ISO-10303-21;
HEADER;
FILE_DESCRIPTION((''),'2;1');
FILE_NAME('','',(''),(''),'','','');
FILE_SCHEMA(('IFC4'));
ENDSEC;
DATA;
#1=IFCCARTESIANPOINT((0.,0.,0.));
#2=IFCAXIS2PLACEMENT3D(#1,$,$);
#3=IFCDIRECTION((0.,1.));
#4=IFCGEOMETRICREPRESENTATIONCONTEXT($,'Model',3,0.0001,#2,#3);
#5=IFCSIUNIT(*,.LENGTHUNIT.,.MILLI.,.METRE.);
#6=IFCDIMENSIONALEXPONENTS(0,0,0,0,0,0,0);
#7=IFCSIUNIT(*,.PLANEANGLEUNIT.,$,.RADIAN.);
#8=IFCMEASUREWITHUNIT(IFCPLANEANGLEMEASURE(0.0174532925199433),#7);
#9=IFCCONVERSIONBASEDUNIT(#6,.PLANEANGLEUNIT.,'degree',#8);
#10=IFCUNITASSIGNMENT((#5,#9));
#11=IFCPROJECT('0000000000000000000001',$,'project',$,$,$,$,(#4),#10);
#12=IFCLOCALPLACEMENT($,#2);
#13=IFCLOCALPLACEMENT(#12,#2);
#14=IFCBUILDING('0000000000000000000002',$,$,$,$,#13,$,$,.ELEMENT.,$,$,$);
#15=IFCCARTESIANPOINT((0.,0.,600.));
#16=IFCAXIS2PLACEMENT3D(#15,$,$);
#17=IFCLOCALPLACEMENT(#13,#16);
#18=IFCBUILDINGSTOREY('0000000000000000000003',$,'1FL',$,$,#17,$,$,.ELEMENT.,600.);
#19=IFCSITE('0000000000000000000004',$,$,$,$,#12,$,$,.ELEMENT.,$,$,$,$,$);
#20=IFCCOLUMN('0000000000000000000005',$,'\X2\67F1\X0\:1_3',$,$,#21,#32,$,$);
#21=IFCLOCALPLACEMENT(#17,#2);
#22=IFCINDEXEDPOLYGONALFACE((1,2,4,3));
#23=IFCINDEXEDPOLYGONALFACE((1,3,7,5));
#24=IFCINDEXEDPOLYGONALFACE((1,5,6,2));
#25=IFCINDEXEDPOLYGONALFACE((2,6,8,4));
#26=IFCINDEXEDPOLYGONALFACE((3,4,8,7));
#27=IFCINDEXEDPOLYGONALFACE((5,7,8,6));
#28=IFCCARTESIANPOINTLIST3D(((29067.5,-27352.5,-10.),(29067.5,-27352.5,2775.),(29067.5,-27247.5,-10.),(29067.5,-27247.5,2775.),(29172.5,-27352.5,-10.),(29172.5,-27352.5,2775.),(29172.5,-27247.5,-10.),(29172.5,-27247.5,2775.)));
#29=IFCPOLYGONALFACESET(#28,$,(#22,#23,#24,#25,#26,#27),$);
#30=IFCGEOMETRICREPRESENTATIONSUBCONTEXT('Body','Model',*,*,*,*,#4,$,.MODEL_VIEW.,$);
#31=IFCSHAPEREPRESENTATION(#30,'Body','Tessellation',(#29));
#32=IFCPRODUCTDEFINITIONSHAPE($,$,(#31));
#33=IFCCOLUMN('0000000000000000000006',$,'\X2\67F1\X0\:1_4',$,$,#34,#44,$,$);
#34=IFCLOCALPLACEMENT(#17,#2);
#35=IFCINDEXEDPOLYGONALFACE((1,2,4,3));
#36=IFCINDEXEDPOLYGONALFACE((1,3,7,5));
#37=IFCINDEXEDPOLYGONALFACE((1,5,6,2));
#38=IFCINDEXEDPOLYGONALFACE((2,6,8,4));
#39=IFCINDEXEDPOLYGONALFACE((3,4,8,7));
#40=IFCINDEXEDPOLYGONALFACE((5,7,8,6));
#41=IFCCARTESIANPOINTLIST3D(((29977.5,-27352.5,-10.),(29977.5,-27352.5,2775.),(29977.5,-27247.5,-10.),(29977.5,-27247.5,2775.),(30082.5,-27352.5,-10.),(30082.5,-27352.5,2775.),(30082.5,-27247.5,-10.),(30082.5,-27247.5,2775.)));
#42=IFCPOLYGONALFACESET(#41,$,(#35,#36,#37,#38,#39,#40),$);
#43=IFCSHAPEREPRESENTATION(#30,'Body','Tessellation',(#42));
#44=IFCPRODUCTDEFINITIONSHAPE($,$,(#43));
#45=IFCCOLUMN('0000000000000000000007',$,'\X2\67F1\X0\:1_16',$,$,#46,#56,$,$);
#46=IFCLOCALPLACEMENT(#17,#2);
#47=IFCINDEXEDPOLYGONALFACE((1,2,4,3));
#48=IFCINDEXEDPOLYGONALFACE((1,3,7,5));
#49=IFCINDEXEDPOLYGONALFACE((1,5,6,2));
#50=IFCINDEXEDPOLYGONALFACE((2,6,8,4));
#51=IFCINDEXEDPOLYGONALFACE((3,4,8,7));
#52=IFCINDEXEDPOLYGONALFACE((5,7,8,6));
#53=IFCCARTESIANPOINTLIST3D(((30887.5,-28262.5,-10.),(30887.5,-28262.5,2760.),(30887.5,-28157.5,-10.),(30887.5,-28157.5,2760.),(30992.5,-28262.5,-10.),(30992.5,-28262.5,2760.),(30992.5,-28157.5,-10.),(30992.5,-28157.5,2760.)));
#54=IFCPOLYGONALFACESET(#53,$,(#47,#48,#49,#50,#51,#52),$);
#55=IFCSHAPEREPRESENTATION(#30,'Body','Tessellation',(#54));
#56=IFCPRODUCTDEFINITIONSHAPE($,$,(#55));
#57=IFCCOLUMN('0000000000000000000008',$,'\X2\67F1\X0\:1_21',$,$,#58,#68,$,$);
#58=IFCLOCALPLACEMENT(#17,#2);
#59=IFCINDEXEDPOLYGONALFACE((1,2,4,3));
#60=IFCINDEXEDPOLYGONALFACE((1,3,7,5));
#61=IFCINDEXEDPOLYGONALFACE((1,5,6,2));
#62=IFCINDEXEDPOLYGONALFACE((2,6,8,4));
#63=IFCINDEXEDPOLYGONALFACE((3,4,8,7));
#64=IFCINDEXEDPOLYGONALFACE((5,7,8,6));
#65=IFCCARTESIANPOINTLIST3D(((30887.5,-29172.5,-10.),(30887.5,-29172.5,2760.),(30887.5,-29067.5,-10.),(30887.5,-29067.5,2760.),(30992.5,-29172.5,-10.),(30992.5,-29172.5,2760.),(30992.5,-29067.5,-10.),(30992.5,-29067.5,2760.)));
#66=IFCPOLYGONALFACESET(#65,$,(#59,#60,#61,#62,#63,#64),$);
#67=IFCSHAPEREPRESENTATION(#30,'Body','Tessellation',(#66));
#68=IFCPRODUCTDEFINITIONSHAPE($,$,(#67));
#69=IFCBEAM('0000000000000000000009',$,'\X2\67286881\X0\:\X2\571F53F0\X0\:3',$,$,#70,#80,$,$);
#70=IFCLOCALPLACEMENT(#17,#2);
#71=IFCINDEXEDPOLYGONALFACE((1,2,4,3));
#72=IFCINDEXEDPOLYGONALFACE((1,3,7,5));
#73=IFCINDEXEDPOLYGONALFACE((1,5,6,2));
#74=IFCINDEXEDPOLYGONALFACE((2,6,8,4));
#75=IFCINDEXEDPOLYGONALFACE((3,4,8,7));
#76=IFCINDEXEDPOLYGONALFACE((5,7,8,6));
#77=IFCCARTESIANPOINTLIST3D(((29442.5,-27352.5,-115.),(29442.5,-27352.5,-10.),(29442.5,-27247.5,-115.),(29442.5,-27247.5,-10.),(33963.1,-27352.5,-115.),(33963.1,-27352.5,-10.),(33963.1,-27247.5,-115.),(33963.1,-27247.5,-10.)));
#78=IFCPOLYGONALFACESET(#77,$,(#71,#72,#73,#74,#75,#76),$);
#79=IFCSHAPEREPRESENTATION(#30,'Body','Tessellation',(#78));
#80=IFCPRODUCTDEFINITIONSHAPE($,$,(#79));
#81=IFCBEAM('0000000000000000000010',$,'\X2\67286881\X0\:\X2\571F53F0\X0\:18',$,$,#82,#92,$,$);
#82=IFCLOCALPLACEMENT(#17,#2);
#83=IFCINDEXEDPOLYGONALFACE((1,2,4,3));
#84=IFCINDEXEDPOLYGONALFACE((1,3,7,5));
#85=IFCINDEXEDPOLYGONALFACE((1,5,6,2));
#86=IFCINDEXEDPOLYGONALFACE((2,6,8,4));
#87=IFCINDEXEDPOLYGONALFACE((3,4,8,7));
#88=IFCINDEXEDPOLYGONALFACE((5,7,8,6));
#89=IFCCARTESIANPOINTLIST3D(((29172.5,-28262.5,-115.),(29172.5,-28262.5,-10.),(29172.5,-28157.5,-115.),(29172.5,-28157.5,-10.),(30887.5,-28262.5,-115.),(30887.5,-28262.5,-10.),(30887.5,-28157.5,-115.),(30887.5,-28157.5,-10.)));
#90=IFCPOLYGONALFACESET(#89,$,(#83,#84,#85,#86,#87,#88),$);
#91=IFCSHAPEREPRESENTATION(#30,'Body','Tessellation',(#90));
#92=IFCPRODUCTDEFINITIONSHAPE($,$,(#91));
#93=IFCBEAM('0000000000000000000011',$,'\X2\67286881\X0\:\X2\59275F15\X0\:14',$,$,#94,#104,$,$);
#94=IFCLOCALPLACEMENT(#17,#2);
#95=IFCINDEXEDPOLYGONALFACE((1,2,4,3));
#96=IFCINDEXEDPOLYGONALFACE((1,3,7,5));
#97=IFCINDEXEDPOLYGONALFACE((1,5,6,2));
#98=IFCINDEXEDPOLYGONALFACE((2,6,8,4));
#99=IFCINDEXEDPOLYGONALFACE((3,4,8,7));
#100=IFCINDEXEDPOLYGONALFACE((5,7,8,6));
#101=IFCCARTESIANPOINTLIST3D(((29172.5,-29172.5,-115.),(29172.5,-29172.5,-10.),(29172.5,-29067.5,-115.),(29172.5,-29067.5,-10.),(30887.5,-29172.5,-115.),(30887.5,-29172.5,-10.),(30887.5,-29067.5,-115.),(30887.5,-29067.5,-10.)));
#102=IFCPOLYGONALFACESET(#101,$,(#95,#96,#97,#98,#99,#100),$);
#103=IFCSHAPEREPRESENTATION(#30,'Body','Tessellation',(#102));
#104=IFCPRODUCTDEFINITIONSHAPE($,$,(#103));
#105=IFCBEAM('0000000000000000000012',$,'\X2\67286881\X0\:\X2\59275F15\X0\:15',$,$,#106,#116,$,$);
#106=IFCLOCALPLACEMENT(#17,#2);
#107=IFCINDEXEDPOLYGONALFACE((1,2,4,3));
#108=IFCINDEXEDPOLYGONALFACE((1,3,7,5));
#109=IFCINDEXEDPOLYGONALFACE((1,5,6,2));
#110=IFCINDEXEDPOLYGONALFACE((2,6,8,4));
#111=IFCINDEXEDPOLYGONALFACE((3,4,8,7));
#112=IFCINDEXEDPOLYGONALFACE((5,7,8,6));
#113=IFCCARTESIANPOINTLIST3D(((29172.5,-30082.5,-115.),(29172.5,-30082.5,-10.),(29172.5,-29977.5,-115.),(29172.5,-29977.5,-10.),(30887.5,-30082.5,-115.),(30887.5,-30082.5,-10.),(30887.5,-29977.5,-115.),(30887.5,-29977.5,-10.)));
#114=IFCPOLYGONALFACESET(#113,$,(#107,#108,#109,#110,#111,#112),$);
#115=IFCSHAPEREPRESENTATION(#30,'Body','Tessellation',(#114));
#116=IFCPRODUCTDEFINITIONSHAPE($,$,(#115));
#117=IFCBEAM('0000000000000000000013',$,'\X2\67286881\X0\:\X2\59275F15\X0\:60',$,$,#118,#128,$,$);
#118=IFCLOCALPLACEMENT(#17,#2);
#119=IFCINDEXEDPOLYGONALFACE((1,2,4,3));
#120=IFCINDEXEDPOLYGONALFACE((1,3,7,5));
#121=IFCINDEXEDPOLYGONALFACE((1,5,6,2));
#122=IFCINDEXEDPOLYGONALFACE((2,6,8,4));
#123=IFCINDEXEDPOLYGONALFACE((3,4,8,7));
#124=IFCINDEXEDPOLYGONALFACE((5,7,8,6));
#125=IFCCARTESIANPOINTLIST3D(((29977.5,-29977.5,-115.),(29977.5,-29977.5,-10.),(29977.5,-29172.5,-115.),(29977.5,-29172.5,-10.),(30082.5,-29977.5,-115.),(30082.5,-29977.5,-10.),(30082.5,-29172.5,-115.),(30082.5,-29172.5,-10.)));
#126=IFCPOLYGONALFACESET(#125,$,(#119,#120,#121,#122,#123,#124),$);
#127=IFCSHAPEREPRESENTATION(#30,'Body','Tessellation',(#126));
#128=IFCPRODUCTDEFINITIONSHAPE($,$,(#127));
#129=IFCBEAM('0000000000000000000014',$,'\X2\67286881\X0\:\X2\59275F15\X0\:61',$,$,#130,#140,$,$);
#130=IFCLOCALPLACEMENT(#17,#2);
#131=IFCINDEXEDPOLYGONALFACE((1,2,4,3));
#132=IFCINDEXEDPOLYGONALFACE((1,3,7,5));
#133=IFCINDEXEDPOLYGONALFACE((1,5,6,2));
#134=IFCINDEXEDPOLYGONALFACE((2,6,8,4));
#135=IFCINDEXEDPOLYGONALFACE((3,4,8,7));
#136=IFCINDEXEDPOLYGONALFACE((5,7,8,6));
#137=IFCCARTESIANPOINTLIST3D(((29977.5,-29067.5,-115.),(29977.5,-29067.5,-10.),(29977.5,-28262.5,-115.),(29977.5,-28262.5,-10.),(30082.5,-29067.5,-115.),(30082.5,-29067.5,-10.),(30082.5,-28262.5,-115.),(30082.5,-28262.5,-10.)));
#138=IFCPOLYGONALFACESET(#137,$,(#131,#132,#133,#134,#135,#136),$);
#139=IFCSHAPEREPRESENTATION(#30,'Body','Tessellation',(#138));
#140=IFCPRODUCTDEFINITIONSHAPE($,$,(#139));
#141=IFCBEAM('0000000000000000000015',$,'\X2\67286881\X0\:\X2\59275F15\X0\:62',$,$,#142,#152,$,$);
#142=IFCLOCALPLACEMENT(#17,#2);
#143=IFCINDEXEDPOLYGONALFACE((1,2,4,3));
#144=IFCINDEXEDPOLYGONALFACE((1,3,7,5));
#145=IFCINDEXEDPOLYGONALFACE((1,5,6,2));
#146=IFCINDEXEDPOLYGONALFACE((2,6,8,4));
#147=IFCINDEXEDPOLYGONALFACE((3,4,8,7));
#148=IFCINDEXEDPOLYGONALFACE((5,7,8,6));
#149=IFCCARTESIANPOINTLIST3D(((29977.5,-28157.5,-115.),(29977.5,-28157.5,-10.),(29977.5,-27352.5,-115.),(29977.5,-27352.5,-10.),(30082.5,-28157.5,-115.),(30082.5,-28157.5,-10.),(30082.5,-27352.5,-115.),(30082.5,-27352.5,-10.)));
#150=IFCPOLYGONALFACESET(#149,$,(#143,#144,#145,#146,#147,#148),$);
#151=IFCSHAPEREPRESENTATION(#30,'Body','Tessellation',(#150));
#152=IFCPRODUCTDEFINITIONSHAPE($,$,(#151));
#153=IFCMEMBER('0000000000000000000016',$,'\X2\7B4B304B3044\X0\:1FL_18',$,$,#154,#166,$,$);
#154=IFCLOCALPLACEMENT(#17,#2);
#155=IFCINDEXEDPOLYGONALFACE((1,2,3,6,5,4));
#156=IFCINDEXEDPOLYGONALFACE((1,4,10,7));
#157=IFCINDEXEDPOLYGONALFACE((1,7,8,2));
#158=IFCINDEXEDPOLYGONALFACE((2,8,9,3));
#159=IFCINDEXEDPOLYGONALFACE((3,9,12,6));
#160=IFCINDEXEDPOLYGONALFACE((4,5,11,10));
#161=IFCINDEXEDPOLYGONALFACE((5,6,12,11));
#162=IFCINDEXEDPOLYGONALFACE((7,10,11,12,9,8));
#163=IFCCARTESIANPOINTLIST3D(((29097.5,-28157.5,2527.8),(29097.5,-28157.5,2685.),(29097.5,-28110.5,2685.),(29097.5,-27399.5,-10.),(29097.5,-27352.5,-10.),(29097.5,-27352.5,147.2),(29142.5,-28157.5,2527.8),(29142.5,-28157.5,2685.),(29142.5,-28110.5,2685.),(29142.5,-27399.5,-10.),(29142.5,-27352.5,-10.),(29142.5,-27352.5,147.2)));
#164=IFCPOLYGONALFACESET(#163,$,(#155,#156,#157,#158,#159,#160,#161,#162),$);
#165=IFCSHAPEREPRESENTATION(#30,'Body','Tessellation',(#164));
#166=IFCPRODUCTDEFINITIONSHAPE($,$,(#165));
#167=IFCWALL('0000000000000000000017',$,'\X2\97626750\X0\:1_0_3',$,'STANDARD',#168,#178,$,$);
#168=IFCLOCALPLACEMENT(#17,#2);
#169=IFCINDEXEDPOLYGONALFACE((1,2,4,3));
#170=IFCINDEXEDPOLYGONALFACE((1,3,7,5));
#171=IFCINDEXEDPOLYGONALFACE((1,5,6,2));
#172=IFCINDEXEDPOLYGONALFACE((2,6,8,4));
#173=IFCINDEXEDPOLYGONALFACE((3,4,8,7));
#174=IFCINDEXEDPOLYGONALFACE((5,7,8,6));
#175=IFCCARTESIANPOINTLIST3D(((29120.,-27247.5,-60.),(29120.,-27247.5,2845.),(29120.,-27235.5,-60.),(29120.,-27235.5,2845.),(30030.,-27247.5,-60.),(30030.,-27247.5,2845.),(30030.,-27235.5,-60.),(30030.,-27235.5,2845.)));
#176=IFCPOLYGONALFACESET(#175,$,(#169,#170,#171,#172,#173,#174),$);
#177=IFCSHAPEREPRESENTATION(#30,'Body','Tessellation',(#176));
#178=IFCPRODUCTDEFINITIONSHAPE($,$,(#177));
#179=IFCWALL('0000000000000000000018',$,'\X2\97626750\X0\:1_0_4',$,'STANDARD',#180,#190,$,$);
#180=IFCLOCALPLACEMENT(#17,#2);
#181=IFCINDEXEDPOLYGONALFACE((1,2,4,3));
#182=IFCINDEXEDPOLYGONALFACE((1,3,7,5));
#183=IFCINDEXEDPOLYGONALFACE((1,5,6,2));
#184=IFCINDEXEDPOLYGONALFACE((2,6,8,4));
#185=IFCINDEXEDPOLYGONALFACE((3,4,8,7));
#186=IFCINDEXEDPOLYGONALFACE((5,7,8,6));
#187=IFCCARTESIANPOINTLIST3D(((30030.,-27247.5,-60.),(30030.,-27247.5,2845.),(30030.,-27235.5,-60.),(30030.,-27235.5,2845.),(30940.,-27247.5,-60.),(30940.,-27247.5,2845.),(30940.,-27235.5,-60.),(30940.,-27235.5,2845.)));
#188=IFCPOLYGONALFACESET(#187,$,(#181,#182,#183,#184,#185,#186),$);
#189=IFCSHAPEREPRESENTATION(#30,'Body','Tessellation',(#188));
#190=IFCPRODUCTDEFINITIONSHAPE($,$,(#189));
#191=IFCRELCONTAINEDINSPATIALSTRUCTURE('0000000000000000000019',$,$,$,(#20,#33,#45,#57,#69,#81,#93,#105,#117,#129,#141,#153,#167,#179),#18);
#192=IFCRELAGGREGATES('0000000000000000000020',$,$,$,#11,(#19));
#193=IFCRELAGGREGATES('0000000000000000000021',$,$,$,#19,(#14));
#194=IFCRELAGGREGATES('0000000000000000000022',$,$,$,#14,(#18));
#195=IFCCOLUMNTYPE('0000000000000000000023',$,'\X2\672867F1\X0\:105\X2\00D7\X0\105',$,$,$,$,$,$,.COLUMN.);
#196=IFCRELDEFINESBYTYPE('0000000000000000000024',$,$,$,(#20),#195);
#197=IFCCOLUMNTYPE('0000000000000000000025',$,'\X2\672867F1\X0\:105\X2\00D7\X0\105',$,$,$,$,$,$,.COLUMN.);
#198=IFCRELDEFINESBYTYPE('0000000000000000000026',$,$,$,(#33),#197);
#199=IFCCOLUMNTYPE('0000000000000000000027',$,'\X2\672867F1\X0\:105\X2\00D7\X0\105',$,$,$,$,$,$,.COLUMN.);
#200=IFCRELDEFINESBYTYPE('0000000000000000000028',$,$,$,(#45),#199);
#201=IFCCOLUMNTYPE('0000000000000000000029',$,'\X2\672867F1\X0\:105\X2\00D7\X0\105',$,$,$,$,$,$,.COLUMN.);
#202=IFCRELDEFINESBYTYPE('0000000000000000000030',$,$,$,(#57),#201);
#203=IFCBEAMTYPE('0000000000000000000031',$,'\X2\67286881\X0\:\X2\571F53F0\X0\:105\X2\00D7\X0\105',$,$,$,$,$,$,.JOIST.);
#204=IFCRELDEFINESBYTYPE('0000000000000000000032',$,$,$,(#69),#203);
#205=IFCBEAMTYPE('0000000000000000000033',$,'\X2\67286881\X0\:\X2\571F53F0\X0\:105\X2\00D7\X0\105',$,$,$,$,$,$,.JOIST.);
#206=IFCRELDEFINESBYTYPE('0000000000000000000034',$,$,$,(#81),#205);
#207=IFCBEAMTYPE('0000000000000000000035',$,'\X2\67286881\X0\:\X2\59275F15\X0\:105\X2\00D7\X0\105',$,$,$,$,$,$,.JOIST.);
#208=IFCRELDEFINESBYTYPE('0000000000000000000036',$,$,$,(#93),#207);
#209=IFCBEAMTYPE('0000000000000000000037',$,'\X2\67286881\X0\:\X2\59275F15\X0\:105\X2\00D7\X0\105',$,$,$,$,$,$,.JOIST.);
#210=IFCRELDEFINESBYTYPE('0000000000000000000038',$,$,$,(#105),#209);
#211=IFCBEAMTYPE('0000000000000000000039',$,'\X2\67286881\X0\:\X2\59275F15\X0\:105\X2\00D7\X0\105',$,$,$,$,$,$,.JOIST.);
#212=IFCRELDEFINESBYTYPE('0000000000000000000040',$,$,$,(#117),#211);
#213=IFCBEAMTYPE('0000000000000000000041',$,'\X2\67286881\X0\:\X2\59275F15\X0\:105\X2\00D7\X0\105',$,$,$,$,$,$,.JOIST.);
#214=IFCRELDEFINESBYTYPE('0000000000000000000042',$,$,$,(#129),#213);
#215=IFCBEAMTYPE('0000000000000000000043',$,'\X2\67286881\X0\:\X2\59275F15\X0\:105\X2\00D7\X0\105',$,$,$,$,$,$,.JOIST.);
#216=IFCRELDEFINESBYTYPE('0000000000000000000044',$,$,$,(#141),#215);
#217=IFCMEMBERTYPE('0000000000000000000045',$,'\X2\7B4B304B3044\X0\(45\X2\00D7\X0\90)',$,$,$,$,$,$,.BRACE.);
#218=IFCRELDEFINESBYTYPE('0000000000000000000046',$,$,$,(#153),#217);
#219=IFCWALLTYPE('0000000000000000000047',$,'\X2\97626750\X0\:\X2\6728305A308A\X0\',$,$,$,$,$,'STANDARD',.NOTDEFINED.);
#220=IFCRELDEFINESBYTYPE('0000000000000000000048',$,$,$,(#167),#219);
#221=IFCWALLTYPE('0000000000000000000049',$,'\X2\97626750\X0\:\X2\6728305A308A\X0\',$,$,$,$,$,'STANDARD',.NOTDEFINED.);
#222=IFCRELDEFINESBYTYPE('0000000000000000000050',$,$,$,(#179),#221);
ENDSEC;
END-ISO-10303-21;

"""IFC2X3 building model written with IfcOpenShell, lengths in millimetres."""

from ifc_helpers import new_model, entity, si_unit, converted_unit, direction, frame, origin, origin_with_axes, origin_2d, place, context, subcontext, project, spatial, polyline, rectangle, outline, extrude, type_object, element, save


model = new_model("IFC2X3")

# Units and contexts
model_context = context("Model", 3, precision=0.0001, world=origin(), true_north=direction((0.0, 1.0)))
body_context = subcontext(model_context, "Body", "Model", "MODEL_VIEW")
ifc_project = project(units=[si_unit("LENGTHUNIT", "METRE", prefix="MILLI"), converted_unit("PLANEANGLEUNIT", "degree", entity("IfcPlaneAngleMeasure", 0.0174532925199433), si_unit("PLANEANGLEUNIT", "RADIAN"), dimensions=[0, 0, 0, 0, 0, 0, 0])], contexts=[model_context])

# Site, building, storey
site_placement = place(None, origin())
site = spatial("IfcSite", under=ifc_project, at=site_placement, CompositionType="ELEMENT")
building_placement = place(site_placement, origin())
building = spatial("IfcBuilding", under=site, at=building_placement, CompositionType="ELEMENT")
storey_placement = place(building_placement, frame((0.0, 0.0, 600.0)))
storey = spatial("IfcBuildingStorey", under=building, at=storey_placement, Name="1FL", CompositionType="ELEMENT", Elevation=600.0)

# Columns
column_type_1 = type_object("IfcColumnType", Name="木柱:105×105", PredefinedType="COLUMN")
column_1_placement = place(storey_placement, frame((29120.0, -27300.0, -10.0)))
element("IfcColumn", 1, at=column_1_placement, inside=storey, type_object=column_type_1, Name="柱:1_3", context=body_context, shape_type="SweptSolid", body=[
    extrude(rectangle(XDim=105.0, YDim=105.0, at=origin_2d()), origin_with_axes(), (0.0, 0.0, 1.0), 2785.0),
])
column_type_2 = type_object("IfcColumnType", Name="木柱:105×105", PredefinedType="COLUMN")
column_2_placement = place(storey_placement, frame((30030.0, -27300.0, -10.0)))
element("IfcColumn", 2, at=column_2_placement, inside=storey, type_object=column_type_2, Name="柱:1_4", context=body_context, shape_type="SweptSolid", body=[
    extrude(rectangle(XDim=105.0, YDim=105.0, at=origin_2d()), origin_with_axes(), (0.0, 0.0, 1.0), 2785.0),
])
column_type_3 = type_object("IfcColumnType", Name="木柱:105×105", PredefinedType="COLUMN")
column_3_placement = place(storey_placement, frame((30940.0, -28210.0, -10.0)))
element("IfcColumn", 3, at=column_3_placement, inside=storey, type_object=column_type_3, Name="柱:1_16", context=body_context, shape_type="SweptSolid", body=[
    extrude(rectangle(XDim=105.0, YDim=105.0, at=origin_2d()), origin_with_axes(), (0.0, 0.0, 1.0), 2770.0),
])
column_type_4 = type_object("IfcColumnType", Name="木柱:105×105", PredefinedType="COLUMN")
column_4_placement = place(storey_placement, frame((30940.0, -29120.0, -10.0)))
element("IfcColumn", 4, at=column_4_placement, inside=storey, type_object=column_type_4, Name="柱:1_21", context=body_context, shape_type="SweptSolid", body=[
    extrude(rectangle(XDim=105.0, YDim=105.0, at=origin_2d()), origin_with_axes(), (0.0, 0.0, 1.0), 2770.0),
])

# Beams
beam_type_1 = type_object("IfcBeamType", Name="木梁:土台:105×105", PredefinedType="JOIST")
beam_1_placement = place(storey_placement, frame((29442.5, -27300.0, -62.5), z_axis=(1.0, 0.0, 0.0), x_axis=(0.0, 1.0, 0.0)))
element("IfcBeam", 5, at=beam_1_placement, inside=storey, type_object=beam_type_1, Name="木梁:土台:3", context=body_context, shape_type="SweptSolid", body=[
    extrude(rectangle(XDim=105.0, YDim=105.0, at=origin_2d()), origin_with_axes(), (0.0, 0.0, 1.0), 4520.6),
])
beam_type_2 = type_object("IfcBeamType", Name="木梁:土台:105×105", PredefinedType="JOIST")
beam_2_placement = place(storey_placement, frame((29172.5, -28210.0, -62.5), z_axis=(1.0, 0.0, 0.0), x_axis=(0.0, 1.0, 0.0)))
element("IfcBeam", 6, at=beam_2_placement, inside=storey, type_object=beam_type_2, Name="木梁:土台:18", context=body_context, shape_type="SweptSolid", body=[
    extrude(rectangle(XDim=105.0, YDim=105.0, at=origin_2d()), origin_with_axes(), (0.0, 0.0, 1.0), 1715.0),
])
beam_type_3 = type_object("IfcBeamType", Name="木梁:大引:105×105", PredefinedType="JOIST")
beam_3_placement = place(storey_placement, frame((29172.5, -29120.0, -62.5), z_axis=(1.0, 0.0, 0.0), x_axis=(0.0, 1.0, 0.0)))
element("IfcBeam", 7, at=beam_3_placement, inside=storey, type_object=beam_type_3, Name="木梁:大引:14", context=body_context, shape_type="SweptSolid", body=[
    extrude(rectangle(XDim=105.0, YDim=105.0, at=origin_2d()), origin_with_axes(), (0.0, 0.0, 1.0), 1715.0),
])
beam_type_4 = type_object("IfcBeamType", Name="木梁:大引:105×105", PredefinedType="JOIST")
beam_4_placement = place(storey_placement, frame((29172.5, -30030.0, -62.5), z_axis=(1.0, 0.0, 0.0), x_axis=(0.0, 1.0, 0.0)))
element("IfcBeam", 8, at=beam_4_placement, inside=storey, type_object=beam_type_4, Name="木梁:大引:15", context=body_context, shape_type="SweptSolid", body=[
    extrude(rectangle(XDim=105.0, YDim=105.0, at=origin_2d()), origin_with_axes(), (0.0, 0.0, 1.0), 1715.0),
])
beam_type_5 = type_object("IfcBeamType", Name="木梁:大引:105×105", PredefinedType="JOIST")
beam_5_placement = place(storey_placement, frame((30030.0, -29172.5, -62.5), z_axis=(0.0, -1.0, 0.0), x_axis=(1.0, 0.0, 0.0)))
element("IfcBeam", 9, at=beam_5_placement, inside=storey, type_object=beam_type_5, Name="木梁:大引:60", context=body_context, shape_type="SweptSolid", body=[
    extrude(rectangle(XDim=105.0, YDim=105.0, at=origin_2d()), origin_with_axes(), (0.0, 0.0, 1.0), 805.0),
])
beam_type_6 = type_object("IfcBeamType", Name="木梁:大引:105×105", PredefinedType="JOIST")
beam_6_placement = place(storey_placement, frame((30030.0, -28262.5, -62.5), z_axis=(0.0, -1.0, 0.0), x_axis=(1.0, 0.0, 0.0)))
element("IfcBeam", 10, at=beam_6_placement, inside=storey, type_object=beam_type_6, Name="木梁:大引:61", context=body_context, shape_type="SweptSolid", body=[
    extrude(rectangle(XDim=105.0, YDim=105.0, at=origin_2d()), origin_with_axes(), (0.0, 0.0, 1.0), 805.0),
])
beam_type_7 = type_object("IfcBeamType", Name="木梁:大引:105×105", PredefinedType="JOIST")
beam_7_placement = place(storey_placement, frame((30030.0, -27352.5, -62.5), z_axis=(0.0, -1.0, 0.0), x_axis=(1.0, 0.0, 0.0)))
element("IfcBeam", 11, at=beam_7_placement, inside=storey, type_object=beam_type_7, Name="木梁:大引:62", context=body_context, shape_type="SweptSolid", body=[
    extrude(rectangle(XDim=105.0, YDim=105.0, at=origin_2d()), origin_with_axes(), (0.0, 0.0, 1.0), 805.0),
])

# Member
member_type = type_object("IfcMemberType", Name="筋かい(45×90)", PredefinedType="BRACE")
member_placement = place(storey_placement, frame((29120.0, -27352.5, -10.0), z_axis=(0.0, -0.286206, 0.958168), x_axis=(0.0, 0.958168, 0.286206)))
element("IfcMember", 12, at=member_placement, inside=storey, type_object=member_type, Name="筋かい:1FL_18", context=body_context, shape_type="SweptSolid", body=[
    extrude(outline(polyline([(0.0, 0.0), (13.4, -45.0), (2662.0, -45.0), (2812.7, 0.0), (2799.2, 45.0), (150.7, 45.0), (0.0, 0.0)])), frame((0.0, -22.5, 0.0), z_axis=(0.0, 1.0, 0.0), x_axis=(0.0, 0.0, 1.0)), (0.0, 0.0, 1.0), 45.0),
])

# Walls
wall_type_1 = type_object("IfcWallType", Name="面材:木ずり", ElementType="STANDARD", PredefinedType="NOTDEFINED")
wall_1_placement = place(storey_placement, frame((29575.0, -27235.5, -60.0), z_axis=(0.0, -1.0, 0.0), x_axis=(1.0, 0.0, 0.0)))
element("IfcWall", 13, at=wall_1_placement, inside=storey, type_object=wall_type_1, Name="面材:1_0_3", ObjectType="STANDARD", context=body_context, shape_type="SweptSolid", body=[
    extrude(outline(polyline([(455.0, 0.0, 0.0), (-455.0, 0.0, 0.0), (-455.0, 2905.0, 0.0), (455.0, 2905.0, 0.0), (455.0, 0.0, 0.0)])), origin_with_axes(), (0.0, 0.0, 1.0), 12.0),
])
wall_type_2 = type_object("IfcWallType", Name="面材:木ずり", ElementType="STANDARD", PredefinedType="NOTDEFINED")
wall_2_placement = place(storey_placement, frame((30485.0, -27235.5, -60.0), z_axis=(0.0, -1.0, 0.0), x_axis=(1.0, 0.0, 0.0)))
element("IfcWall", 14, at=wall_2_placement, inside=storey, type_object=wall_type_2, Name="面材:1_0_4", ObjectType="STANDARD", context=body_context, shape_type="SweptSolid", body=[
    extrude(outline(polyline([(455.0, 0.0, 0.0), (-455.0, 0.0, 0.0), (-455.0, 2905.0, 0.0), (455.0, 2905.0, 0.0), (455.0, 0.0, 0.0)])), origin_with_axes(), (0.0, 0.0, 1.0), 12.0),
])

save(model, "model.ifc")
